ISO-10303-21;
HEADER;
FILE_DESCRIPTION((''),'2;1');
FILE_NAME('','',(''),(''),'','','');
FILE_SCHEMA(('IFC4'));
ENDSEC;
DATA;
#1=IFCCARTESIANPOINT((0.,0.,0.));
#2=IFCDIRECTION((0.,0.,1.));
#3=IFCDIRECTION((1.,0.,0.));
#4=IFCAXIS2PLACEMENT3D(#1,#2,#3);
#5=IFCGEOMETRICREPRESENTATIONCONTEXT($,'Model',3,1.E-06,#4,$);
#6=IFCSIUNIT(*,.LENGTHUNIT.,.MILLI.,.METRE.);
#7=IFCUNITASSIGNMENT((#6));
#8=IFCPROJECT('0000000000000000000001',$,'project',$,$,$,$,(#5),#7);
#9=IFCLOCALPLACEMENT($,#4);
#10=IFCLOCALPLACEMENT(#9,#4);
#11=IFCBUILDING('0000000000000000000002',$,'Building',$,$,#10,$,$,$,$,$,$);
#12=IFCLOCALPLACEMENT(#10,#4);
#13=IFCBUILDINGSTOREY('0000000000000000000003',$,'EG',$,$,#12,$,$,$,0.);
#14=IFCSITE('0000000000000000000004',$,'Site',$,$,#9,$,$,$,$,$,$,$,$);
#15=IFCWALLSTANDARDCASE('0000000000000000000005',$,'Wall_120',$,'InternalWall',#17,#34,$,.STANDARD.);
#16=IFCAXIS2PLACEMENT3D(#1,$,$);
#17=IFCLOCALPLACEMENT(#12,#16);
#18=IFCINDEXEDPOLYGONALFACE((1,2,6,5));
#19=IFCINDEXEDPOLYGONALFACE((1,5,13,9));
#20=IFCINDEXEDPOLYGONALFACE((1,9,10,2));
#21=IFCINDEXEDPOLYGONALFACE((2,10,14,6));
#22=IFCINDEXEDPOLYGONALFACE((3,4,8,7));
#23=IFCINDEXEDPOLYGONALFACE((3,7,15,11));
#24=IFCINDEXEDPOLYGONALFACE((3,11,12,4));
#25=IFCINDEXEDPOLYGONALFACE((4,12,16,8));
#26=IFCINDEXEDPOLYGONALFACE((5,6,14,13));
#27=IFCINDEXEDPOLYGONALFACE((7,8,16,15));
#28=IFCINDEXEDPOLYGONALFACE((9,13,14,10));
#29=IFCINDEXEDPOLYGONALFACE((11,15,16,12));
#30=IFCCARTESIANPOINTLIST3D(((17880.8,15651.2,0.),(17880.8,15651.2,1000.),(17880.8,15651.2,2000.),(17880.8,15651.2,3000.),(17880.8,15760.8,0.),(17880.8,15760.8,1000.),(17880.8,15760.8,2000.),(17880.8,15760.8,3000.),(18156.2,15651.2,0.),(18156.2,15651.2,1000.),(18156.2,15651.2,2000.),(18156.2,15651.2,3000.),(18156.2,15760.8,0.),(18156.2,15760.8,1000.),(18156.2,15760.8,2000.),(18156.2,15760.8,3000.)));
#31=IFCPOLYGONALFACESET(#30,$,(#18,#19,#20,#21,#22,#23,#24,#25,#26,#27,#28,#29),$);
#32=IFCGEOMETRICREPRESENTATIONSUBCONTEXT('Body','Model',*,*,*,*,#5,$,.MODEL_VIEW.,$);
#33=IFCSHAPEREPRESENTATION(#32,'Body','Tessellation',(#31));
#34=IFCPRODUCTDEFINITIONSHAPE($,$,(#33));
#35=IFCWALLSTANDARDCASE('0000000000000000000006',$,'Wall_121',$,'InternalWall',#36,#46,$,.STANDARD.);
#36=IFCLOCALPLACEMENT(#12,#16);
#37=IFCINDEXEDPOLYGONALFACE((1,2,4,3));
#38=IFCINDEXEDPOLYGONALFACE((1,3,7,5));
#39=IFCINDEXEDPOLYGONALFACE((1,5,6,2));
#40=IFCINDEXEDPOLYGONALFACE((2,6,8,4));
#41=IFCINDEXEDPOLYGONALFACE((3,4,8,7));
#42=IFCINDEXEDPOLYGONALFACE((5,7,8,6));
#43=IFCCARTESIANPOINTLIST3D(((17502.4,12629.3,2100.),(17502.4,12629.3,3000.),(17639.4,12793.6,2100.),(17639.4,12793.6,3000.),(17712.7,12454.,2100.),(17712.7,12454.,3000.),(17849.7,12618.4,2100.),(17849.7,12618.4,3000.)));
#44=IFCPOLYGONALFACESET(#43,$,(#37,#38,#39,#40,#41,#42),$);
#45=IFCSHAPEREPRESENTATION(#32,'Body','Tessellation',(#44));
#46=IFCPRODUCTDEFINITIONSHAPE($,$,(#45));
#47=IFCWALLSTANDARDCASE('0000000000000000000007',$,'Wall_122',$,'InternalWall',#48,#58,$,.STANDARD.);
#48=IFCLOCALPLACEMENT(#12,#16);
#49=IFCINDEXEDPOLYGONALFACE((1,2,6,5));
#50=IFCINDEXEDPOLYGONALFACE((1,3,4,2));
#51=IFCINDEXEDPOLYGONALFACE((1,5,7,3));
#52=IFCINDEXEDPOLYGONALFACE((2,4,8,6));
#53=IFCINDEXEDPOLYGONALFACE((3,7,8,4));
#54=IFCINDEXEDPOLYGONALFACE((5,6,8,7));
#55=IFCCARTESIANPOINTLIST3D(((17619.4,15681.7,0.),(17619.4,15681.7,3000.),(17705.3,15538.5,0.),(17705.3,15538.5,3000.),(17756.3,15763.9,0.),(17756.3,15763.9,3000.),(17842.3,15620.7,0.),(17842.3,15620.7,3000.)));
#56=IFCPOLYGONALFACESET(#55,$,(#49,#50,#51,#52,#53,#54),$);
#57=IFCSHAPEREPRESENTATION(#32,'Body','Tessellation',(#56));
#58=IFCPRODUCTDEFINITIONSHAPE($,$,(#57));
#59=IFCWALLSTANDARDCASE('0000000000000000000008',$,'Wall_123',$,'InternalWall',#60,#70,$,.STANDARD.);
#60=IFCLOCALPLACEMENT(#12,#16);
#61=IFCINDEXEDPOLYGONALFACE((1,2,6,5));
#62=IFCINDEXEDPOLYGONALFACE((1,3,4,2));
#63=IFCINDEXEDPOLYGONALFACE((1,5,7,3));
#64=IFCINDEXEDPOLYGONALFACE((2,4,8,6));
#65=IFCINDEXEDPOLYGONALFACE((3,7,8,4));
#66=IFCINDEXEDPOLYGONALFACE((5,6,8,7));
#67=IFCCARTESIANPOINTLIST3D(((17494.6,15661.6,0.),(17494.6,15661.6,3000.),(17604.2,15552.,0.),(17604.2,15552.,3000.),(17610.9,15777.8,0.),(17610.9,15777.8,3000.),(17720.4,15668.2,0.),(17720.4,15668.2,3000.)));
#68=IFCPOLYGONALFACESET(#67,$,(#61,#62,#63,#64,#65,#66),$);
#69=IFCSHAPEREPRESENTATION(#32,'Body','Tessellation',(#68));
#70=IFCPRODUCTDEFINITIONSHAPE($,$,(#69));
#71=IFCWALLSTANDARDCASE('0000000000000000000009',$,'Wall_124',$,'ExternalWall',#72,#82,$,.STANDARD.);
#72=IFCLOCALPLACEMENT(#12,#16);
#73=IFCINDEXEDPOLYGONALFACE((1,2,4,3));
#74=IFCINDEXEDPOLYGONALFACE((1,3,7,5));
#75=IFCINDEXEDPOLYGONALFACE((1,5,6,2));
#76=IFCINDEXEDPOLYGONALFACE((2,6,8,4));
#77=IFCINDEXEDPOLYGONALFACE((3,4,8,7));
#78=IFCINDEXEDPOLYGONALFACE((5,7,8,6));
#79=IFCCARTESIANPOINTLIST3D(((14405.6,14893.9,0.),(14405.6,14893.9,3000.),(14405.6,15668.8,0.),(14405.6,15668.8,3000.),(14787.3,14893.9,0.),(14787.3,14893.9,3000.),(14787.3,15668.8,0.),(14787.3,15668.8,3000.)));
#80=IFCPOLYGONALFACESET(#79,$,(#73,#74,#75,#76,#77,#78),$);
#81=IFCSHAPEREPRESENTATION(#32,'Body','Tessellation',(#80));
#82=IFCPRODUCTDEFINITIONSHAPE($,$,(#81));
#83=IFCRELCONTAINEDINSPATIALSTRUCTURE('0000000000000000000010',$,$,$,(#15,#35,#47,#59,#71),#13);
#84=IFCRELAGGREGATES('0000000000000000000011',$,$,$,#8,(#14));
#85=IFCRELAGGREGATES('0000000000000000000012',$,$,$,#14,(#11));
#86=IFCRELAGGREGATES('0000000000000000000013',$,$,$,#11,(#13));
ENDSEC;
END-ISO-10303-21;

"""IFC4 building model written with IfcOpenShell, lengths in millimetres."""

from ifc_helpers import new_model, si_unit, frame, origin_with_axes, place, context, subcontext, project, spatial, rectangle, extrude, element, save


model = new_model("IFC4")

# Units and contexts
model_context = context("Model", 3, precision=1e-06, world=origin_with_axes())
body_context = subcontext(model_context, "Body", "Model", "MODEL_VIEW")
ifc_project = project(units=[si_unit("LENGTHUNIT", "METRE", prefix="MILLI")], contexts=[model_context])

# Site, building, storey
site_placement = place(None, origin_with_axes())
site = spatial("IfcSite", under=ifc_project, at=site_placement, Name="Site")
building_placement = place(site_placement, origin_with_axes())
building = spatial("IfcBuilding", under=site, at=building_placement, Name="Building")
storey_placement = place(building_placement, origin_with_axes())
storey = spatial("IfcBuildingStorey", under=building, at=storey_placement, Name="EG", Elevation=0.0)

# Walls, openings
wall_1_placement = place(storey_placement, origin_with_axes())
wall_1 = element("IfcWallStandardCase", 1, at=wall_1_placement, inside=storey, Name="Wall_120", ObjectType="InternalWall", PredefinedType="STANDARD", context=body_context, shape_type="SweptSolid", body=[
    extrude(rectangle(XDim=275.3, YDim=109.6), frame((18018.5, 15706.0, 0.0), z_axis=(0.0, 0.0, 1.0), x_axis=(1.0, 0.0, 0.0)), (0.0, 0.0, 1.0), 3000.0),
])
opening_1_placement = place(wall_1_placement, origin_with_axes())
element("IfcOpeningElement", 2, at=opening_1_placement, inside=storey, cuts=wall_1, context=body_context, shape_type="SweptSolid", body=[
    extrude(rectangle(XDim=600.0, YDim=109.6), frame((18018.5, 15706.0, 1000.0), z_axis=(0.0, 0.0, 1.0), x_axis=(1.0, 0.0, 0.0)), (0.0, 0.0, 1.0), 1000.0),
])
wall_2_placement = place(storey_placement, origin_with_axes())
wall_2 = element("IfcWallStandardCase", 3, at=wall_2_placement, inside=storey, Name="Wall_121", ObjectType="InternalWall", PredefinedType="STANDARD", context=body_context, shape_type="SweptSolid", body=[
    extrude(rectangle(XDim=214.0, YDim=273.8), frame((17676.0, 12623.8, 0.0), z_axis=(0.0, 0.0, 1.0), x_axis=(-0.640184, -0.768221, 0.0)), (0.0, 0.0, 1.0), 3000.0),
])
opening_2_placement = place(wall_2_placement, origin_with_axes())
element("IfcOpeningElement", 4, at=opening_2_placement, inside=storey, cuts=wall_2, context=body_context, shape_type="SweptSolid", body=[
    extrude(rectangle(XDim=450.0, YDim=273.8), frame((17676.0, 12623.8, 0.0), z_axis=(0.0, 0.0, 1.0), x_axis=(-0.640184, -0.768221, 0.0)), (0.0, 0.0, 1.0), 2100.0),
])

# Walls
wall_3_placement = place(storey_placement, origin_with_axes())
element("IfcWallStandardCase", 5, at=wall_3_placement, inside=storey, Name="Wall_122", ObjectType="InternalWall", PredefinedType="STANDARD", context=body_context, shape_type="SweptSolid", body=[
    extrude(rectangle(XDim=159.8, YDim=167.0), frame((17730.8, 15651.2, 0.0), z_axis=(0.0, 0.0, 1.0), x_axis=(0.857493, 0.514496, 0.0)), (0.0, 0.0, 1.0), 3000.0),
])
wall_4_placement = place(storey_placement, origin_with_axes())
element("IfcWallStandardCase", 6, at=wall_4_placement, inside=storey, Name="Wall_123", ObjectType="InternalWall", PredefinedType="STANDARD", context=body_context, shape_type="SweptSolid", body=[
    extrude(rectangle(XDim=155.0, YDim=164.4), frame((17607.5, 15664.9, 0.0), z_axis=(0.0, 0.0, 1.0), x_axis=(-0.707107, 0.707107, 0.0)), (0.0, 0.0, 1.0), 3000.0),
])
wall_5_placement = place(storey_placement, origin_with_axes())
element("IfcWallStandardCase", 7, at=wall_5_placement, inside=storey, Name="Wall_124", ObjectType="ExternalWall", PredefinedType="STANDARD", context=body_context, shape_type="SweptSolid", body=[
    extrude(rectangle(XDim=774.9, YDim=381.7), frame((14596.4, 15281.3, 0.0), z_axis=(0.0, 0.0, 1.0), x_axis=(0.0, 1.0, 0.0)), (0.0, 0.0, 1.0), 3000.0),
])

save(model, "model.ifc")
